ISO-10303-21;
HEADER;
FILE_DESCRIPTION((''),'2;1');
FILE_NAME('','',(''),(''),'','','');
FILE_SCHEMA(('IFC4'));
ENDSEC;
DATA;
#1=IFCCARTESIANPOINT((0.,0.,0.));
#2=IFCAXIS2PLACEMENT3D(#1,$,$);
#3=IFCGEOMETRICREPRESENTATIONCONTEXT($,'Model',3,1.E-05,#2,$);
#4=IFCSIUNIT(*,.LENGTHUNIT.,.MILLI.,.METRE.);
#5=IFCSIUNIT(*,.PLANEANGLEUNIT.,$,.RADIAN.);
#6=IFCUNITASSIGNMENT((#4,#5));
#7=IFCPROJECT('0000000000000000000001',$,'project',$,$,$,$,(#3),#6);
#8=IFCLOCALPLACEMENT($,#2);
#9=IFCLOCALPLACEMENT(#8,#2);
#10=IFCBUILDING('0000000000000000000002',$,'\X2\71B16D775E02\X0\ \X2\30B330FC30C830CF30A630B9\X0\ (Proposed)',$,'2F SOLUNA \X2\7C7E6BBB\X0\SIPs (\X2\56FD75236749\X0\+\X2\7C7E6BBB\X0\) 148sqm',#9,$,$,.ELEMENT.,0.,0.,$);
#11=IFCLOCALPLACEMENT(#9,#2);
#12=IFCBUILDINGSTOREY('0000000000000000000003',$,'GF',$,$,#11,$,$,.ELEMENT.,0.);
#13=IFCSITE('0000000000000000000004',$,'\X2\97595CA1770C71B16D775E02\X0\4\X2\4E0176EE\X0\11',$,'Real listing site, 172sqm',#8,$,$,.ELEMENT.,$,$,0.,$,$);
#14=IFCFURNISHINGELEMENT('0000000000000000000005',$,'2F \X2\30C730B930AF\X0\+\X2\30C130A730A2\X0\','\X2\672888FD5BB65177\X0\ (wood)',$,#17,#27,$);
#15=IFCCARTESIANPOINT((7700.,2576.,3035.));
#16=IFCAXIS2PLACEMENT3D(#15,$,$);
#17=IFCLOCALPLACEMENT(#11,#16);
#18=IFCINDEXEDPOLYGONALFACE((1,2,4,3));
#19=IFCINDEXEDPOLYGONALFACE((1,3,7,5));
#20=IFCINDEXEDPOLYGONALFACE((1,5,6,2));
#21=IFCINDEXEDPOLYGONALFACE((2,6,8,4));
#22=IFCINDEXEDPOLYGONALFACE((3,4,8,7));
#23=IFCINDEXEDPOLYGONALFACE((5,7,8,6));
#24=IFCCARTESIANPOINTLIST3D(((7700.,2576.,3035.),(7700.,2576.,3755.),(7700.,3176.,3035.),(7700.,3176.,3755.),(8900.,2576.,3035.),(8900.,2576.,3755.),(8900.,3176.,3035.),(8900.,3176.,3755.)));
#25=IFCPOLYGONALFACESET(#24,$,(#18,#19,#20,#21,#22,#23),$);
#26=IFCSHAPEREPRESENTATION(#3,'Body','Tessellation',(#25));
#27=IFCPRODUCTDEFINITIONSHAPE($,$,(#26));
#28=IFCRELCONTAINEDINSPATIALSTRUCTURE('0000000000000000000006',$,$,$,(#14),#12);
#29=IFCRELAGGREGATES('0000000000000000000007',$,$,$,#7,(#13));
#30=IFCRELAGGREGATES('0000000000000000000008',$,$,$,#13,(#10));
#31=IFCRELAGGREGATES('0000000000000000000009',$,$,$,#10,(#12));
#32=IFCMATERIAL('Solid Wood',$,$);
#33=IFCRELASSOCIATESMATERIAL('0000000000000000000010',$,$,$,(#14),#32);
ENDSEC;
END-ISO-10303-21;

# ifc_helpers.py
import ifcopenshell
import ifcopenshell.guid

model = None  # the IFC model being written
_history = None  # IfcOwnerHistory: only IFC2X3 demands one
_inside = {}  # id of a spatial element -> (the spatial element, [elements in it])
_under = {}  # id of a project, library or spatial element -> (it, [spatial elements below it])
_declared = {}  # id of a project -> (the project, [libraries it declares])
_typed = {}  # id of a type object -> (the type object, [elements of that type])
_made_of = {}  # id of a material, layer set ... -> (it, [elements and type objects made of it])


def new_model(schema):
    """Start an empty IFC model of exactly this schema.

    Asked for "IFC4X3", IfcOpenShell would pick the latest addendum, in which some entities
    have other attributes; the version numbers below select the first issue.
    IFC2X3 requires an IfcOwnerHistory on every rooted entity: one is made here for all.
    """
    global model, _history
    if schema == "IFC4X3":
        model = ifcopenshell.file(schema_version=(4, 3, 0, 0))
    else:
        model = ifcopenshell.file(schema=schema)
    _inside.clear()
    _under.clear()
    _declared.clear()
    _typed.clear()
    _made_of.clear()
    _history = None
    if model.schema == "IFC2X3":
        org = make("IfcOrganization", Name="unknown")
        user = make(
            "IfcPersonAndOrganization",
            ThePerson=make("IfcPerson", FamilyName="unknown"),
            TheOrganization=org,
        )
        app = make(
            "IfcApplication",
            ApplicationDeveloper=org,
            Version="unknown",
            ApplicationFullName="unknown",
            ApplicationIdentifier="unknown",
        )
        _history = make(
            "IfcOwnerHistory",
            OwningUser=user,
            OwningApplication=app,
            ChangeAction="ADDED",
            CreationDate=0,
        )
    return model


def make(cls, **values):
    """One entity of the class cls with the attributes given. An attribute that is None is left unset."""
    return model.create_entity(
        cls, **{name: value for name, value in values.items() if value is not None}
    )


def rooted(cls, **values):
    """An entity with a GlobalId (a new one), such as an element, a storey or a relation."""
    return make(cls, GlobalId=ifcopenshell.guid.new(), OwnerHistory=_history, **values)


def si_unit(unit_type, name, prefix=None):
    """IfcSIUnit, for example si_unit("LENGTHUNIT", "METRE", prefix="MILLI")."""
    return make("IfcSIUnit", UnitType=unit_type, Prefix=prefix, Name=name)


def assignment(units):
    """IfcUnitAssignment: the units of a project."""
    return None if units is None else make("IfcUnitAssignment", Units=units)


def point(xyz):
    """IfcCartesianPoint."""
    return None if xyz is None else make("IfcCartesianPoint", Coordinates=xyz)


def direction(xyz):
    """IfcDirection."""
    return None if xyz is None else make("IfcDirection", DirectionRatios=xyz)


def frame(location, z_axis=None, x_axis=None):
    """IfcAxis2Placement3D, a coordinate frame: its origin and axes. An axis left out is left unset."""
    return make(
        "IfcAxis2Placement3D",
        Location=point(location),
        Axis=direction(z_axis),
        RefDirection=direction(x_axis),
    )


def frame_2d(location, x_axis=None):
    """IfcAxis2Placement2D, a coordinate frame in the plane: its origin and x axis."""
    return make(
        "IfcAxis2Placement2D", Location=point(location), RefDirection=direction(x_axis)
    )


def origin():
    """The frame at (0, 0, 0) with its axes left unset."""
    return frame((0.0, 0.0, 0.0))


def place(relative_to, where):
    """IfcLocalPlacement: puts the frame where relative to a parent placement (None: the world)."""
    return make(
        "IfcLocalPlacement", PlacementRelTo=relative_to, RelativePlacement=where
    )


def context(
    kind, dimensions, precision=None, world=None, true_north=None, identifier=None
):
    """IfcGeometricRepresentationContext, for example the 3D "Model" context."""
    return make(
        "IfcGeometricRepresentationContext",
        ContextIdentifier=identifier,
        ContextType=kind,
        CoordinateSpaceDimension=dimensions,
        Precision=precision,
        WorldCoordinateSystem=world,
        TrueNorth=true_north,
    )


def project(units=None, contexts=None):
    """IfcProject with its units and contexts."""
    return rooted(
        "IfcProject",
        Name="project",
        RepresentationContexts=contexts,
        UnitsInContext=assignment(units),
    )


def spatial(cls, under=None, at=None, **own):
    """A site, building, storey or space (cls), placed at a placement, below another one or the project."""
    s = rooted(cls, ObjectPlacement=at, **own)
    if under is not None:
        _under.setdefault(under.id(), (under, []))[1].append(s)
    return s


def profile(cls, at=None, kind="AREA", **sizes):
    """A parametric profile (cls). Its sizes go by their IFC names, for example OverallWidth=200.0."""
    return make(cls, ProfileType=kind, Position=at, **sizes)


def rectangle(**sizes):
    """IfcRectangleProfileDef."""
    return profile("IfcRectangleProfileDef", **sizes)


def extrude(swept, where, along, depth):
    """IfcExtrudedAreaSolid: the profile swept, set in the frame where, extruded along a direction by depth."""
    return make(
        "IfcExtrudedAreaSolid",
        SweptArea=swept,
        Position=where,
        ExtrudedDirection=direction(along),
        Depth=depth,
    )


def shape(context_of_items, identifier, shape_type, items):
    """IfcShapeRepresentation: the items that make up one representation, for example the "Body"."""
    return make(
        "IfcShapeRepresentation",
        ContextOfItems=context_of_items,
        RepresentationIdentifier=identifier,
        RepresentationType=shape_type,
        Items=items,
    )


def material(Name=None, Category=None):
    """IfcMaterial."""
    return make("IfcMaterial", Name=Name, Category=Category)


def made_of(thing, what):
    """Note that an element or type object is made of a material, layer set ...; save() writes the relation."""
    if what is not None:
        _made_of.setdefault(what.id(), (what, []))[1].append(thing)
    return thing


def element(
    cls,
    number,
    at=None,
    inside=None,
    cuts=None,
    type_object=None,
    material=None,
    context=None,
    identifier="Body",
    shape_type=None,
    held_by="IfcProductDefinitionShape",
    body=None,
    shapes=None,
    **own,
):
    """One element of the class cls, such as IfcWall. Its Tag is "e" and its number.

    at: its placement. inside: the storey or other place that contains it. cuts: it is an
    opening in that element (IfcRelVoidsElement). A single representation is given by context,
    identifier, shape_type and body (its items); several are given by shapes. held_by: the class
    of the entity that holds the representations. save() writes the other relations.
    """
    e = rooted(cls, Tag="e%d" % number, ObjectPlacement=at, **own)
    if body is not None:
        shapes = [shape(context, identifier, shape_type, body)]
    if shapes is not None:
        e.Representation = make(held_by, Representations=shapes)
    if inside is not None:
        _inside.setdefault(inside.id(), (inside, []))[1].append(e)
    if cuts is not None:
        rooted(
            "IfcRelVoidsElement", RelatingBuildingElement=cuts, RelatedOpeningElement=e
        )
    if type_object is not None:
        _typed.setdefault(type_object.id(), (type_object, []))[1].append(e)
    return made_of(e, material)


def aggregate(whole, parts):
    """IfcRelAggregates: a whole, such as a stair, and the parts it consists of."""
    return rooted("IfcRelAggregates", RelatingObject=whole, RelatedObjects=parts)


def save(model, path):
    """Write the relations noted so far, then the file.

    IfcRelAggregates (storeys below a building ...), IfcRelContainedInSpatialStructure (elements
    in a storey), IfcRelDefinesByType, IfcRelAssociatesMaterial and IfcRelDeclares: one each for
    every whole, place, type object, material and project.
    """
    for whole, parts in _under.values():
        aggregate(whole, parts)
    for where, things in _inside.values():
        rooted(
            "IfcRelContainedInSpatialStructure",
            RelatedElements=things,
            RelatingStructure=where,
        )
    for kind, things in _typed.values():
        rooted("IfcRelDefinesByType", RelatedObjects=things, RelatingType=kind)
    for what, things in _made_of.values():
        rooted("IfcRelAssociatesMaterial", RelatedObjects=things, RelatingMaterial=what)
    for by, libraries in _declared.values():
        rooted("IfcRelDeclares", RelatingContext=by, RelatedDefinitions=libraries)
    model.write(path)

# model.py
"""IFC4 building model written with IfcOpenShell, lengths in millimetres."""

from ifc_helpers import new_model, si_unit, frame, frame_2d, origin, place, context, project, spatial, rectangle, extrude, material, element, save


model = new_model("IFC4")

# Units and contexts
model_context = context("Model", 3, precision=1e-05, world=origin())
ifc_project = project(units=[si_unit("LENGTHUNIT", "METRE", prefix="MILLI"), si_unit("PLANEANGLEUNIT", "RADIAN")], contexts=[model_context])

# Site, building, storey
site_placement = place(None, origin())
site = spatial("IfcSite", under=ifc_project, at=site_placement, Name="静岡県熱海市4丁目11", ObjectType="Real listing site, 172sqm", CompositionType="ELEMENT", RefElevation=0.0)
building_placement = place(site_placement, origin())
building = spatial("IfcBuilding", under=site, at=building_placement, Name="熱海市 コートハウス (Proposed)", ObjectType="2F SOLUNA 籾殻SIPs (国産杉+籾殻) 148sqm", CompositionType="ELEMENT", ElevationOfRefHeight=0.0, ElevationOfTerrain=0.0)
storey_placement = place(building_placement, origin())
storey = spatial("IfcBuildingStorey", under=building, at=storey_placement, Name="GF", CompositionType="ELEMENT", Elevation=0.0)

# Shared definitions
ifc_material_1 = material(Name="Solid Wood")

# Furnishing element
furnishing_1_placement = place(storey_placement, frame((7700.0, 2576.0, 3035.0)))
element("IfcFurnishingElement", 1, at=furnishing_1_placement, inside=storey, material=ifc_material_1, Name="2F デスク+チェア", Description="木製家具 (wood)", context=model_context, shape_type="SweptSolid", body=[
    extrude(rectangle(XDim=1200.0, YDim=600.0, at=frame_2d((600.0, 300.0))), frame((7700.0, 2576.0, 3035.0)), (0.0, 0.0, 1.0), 720.0),
])

save(model, "model.ifc")
